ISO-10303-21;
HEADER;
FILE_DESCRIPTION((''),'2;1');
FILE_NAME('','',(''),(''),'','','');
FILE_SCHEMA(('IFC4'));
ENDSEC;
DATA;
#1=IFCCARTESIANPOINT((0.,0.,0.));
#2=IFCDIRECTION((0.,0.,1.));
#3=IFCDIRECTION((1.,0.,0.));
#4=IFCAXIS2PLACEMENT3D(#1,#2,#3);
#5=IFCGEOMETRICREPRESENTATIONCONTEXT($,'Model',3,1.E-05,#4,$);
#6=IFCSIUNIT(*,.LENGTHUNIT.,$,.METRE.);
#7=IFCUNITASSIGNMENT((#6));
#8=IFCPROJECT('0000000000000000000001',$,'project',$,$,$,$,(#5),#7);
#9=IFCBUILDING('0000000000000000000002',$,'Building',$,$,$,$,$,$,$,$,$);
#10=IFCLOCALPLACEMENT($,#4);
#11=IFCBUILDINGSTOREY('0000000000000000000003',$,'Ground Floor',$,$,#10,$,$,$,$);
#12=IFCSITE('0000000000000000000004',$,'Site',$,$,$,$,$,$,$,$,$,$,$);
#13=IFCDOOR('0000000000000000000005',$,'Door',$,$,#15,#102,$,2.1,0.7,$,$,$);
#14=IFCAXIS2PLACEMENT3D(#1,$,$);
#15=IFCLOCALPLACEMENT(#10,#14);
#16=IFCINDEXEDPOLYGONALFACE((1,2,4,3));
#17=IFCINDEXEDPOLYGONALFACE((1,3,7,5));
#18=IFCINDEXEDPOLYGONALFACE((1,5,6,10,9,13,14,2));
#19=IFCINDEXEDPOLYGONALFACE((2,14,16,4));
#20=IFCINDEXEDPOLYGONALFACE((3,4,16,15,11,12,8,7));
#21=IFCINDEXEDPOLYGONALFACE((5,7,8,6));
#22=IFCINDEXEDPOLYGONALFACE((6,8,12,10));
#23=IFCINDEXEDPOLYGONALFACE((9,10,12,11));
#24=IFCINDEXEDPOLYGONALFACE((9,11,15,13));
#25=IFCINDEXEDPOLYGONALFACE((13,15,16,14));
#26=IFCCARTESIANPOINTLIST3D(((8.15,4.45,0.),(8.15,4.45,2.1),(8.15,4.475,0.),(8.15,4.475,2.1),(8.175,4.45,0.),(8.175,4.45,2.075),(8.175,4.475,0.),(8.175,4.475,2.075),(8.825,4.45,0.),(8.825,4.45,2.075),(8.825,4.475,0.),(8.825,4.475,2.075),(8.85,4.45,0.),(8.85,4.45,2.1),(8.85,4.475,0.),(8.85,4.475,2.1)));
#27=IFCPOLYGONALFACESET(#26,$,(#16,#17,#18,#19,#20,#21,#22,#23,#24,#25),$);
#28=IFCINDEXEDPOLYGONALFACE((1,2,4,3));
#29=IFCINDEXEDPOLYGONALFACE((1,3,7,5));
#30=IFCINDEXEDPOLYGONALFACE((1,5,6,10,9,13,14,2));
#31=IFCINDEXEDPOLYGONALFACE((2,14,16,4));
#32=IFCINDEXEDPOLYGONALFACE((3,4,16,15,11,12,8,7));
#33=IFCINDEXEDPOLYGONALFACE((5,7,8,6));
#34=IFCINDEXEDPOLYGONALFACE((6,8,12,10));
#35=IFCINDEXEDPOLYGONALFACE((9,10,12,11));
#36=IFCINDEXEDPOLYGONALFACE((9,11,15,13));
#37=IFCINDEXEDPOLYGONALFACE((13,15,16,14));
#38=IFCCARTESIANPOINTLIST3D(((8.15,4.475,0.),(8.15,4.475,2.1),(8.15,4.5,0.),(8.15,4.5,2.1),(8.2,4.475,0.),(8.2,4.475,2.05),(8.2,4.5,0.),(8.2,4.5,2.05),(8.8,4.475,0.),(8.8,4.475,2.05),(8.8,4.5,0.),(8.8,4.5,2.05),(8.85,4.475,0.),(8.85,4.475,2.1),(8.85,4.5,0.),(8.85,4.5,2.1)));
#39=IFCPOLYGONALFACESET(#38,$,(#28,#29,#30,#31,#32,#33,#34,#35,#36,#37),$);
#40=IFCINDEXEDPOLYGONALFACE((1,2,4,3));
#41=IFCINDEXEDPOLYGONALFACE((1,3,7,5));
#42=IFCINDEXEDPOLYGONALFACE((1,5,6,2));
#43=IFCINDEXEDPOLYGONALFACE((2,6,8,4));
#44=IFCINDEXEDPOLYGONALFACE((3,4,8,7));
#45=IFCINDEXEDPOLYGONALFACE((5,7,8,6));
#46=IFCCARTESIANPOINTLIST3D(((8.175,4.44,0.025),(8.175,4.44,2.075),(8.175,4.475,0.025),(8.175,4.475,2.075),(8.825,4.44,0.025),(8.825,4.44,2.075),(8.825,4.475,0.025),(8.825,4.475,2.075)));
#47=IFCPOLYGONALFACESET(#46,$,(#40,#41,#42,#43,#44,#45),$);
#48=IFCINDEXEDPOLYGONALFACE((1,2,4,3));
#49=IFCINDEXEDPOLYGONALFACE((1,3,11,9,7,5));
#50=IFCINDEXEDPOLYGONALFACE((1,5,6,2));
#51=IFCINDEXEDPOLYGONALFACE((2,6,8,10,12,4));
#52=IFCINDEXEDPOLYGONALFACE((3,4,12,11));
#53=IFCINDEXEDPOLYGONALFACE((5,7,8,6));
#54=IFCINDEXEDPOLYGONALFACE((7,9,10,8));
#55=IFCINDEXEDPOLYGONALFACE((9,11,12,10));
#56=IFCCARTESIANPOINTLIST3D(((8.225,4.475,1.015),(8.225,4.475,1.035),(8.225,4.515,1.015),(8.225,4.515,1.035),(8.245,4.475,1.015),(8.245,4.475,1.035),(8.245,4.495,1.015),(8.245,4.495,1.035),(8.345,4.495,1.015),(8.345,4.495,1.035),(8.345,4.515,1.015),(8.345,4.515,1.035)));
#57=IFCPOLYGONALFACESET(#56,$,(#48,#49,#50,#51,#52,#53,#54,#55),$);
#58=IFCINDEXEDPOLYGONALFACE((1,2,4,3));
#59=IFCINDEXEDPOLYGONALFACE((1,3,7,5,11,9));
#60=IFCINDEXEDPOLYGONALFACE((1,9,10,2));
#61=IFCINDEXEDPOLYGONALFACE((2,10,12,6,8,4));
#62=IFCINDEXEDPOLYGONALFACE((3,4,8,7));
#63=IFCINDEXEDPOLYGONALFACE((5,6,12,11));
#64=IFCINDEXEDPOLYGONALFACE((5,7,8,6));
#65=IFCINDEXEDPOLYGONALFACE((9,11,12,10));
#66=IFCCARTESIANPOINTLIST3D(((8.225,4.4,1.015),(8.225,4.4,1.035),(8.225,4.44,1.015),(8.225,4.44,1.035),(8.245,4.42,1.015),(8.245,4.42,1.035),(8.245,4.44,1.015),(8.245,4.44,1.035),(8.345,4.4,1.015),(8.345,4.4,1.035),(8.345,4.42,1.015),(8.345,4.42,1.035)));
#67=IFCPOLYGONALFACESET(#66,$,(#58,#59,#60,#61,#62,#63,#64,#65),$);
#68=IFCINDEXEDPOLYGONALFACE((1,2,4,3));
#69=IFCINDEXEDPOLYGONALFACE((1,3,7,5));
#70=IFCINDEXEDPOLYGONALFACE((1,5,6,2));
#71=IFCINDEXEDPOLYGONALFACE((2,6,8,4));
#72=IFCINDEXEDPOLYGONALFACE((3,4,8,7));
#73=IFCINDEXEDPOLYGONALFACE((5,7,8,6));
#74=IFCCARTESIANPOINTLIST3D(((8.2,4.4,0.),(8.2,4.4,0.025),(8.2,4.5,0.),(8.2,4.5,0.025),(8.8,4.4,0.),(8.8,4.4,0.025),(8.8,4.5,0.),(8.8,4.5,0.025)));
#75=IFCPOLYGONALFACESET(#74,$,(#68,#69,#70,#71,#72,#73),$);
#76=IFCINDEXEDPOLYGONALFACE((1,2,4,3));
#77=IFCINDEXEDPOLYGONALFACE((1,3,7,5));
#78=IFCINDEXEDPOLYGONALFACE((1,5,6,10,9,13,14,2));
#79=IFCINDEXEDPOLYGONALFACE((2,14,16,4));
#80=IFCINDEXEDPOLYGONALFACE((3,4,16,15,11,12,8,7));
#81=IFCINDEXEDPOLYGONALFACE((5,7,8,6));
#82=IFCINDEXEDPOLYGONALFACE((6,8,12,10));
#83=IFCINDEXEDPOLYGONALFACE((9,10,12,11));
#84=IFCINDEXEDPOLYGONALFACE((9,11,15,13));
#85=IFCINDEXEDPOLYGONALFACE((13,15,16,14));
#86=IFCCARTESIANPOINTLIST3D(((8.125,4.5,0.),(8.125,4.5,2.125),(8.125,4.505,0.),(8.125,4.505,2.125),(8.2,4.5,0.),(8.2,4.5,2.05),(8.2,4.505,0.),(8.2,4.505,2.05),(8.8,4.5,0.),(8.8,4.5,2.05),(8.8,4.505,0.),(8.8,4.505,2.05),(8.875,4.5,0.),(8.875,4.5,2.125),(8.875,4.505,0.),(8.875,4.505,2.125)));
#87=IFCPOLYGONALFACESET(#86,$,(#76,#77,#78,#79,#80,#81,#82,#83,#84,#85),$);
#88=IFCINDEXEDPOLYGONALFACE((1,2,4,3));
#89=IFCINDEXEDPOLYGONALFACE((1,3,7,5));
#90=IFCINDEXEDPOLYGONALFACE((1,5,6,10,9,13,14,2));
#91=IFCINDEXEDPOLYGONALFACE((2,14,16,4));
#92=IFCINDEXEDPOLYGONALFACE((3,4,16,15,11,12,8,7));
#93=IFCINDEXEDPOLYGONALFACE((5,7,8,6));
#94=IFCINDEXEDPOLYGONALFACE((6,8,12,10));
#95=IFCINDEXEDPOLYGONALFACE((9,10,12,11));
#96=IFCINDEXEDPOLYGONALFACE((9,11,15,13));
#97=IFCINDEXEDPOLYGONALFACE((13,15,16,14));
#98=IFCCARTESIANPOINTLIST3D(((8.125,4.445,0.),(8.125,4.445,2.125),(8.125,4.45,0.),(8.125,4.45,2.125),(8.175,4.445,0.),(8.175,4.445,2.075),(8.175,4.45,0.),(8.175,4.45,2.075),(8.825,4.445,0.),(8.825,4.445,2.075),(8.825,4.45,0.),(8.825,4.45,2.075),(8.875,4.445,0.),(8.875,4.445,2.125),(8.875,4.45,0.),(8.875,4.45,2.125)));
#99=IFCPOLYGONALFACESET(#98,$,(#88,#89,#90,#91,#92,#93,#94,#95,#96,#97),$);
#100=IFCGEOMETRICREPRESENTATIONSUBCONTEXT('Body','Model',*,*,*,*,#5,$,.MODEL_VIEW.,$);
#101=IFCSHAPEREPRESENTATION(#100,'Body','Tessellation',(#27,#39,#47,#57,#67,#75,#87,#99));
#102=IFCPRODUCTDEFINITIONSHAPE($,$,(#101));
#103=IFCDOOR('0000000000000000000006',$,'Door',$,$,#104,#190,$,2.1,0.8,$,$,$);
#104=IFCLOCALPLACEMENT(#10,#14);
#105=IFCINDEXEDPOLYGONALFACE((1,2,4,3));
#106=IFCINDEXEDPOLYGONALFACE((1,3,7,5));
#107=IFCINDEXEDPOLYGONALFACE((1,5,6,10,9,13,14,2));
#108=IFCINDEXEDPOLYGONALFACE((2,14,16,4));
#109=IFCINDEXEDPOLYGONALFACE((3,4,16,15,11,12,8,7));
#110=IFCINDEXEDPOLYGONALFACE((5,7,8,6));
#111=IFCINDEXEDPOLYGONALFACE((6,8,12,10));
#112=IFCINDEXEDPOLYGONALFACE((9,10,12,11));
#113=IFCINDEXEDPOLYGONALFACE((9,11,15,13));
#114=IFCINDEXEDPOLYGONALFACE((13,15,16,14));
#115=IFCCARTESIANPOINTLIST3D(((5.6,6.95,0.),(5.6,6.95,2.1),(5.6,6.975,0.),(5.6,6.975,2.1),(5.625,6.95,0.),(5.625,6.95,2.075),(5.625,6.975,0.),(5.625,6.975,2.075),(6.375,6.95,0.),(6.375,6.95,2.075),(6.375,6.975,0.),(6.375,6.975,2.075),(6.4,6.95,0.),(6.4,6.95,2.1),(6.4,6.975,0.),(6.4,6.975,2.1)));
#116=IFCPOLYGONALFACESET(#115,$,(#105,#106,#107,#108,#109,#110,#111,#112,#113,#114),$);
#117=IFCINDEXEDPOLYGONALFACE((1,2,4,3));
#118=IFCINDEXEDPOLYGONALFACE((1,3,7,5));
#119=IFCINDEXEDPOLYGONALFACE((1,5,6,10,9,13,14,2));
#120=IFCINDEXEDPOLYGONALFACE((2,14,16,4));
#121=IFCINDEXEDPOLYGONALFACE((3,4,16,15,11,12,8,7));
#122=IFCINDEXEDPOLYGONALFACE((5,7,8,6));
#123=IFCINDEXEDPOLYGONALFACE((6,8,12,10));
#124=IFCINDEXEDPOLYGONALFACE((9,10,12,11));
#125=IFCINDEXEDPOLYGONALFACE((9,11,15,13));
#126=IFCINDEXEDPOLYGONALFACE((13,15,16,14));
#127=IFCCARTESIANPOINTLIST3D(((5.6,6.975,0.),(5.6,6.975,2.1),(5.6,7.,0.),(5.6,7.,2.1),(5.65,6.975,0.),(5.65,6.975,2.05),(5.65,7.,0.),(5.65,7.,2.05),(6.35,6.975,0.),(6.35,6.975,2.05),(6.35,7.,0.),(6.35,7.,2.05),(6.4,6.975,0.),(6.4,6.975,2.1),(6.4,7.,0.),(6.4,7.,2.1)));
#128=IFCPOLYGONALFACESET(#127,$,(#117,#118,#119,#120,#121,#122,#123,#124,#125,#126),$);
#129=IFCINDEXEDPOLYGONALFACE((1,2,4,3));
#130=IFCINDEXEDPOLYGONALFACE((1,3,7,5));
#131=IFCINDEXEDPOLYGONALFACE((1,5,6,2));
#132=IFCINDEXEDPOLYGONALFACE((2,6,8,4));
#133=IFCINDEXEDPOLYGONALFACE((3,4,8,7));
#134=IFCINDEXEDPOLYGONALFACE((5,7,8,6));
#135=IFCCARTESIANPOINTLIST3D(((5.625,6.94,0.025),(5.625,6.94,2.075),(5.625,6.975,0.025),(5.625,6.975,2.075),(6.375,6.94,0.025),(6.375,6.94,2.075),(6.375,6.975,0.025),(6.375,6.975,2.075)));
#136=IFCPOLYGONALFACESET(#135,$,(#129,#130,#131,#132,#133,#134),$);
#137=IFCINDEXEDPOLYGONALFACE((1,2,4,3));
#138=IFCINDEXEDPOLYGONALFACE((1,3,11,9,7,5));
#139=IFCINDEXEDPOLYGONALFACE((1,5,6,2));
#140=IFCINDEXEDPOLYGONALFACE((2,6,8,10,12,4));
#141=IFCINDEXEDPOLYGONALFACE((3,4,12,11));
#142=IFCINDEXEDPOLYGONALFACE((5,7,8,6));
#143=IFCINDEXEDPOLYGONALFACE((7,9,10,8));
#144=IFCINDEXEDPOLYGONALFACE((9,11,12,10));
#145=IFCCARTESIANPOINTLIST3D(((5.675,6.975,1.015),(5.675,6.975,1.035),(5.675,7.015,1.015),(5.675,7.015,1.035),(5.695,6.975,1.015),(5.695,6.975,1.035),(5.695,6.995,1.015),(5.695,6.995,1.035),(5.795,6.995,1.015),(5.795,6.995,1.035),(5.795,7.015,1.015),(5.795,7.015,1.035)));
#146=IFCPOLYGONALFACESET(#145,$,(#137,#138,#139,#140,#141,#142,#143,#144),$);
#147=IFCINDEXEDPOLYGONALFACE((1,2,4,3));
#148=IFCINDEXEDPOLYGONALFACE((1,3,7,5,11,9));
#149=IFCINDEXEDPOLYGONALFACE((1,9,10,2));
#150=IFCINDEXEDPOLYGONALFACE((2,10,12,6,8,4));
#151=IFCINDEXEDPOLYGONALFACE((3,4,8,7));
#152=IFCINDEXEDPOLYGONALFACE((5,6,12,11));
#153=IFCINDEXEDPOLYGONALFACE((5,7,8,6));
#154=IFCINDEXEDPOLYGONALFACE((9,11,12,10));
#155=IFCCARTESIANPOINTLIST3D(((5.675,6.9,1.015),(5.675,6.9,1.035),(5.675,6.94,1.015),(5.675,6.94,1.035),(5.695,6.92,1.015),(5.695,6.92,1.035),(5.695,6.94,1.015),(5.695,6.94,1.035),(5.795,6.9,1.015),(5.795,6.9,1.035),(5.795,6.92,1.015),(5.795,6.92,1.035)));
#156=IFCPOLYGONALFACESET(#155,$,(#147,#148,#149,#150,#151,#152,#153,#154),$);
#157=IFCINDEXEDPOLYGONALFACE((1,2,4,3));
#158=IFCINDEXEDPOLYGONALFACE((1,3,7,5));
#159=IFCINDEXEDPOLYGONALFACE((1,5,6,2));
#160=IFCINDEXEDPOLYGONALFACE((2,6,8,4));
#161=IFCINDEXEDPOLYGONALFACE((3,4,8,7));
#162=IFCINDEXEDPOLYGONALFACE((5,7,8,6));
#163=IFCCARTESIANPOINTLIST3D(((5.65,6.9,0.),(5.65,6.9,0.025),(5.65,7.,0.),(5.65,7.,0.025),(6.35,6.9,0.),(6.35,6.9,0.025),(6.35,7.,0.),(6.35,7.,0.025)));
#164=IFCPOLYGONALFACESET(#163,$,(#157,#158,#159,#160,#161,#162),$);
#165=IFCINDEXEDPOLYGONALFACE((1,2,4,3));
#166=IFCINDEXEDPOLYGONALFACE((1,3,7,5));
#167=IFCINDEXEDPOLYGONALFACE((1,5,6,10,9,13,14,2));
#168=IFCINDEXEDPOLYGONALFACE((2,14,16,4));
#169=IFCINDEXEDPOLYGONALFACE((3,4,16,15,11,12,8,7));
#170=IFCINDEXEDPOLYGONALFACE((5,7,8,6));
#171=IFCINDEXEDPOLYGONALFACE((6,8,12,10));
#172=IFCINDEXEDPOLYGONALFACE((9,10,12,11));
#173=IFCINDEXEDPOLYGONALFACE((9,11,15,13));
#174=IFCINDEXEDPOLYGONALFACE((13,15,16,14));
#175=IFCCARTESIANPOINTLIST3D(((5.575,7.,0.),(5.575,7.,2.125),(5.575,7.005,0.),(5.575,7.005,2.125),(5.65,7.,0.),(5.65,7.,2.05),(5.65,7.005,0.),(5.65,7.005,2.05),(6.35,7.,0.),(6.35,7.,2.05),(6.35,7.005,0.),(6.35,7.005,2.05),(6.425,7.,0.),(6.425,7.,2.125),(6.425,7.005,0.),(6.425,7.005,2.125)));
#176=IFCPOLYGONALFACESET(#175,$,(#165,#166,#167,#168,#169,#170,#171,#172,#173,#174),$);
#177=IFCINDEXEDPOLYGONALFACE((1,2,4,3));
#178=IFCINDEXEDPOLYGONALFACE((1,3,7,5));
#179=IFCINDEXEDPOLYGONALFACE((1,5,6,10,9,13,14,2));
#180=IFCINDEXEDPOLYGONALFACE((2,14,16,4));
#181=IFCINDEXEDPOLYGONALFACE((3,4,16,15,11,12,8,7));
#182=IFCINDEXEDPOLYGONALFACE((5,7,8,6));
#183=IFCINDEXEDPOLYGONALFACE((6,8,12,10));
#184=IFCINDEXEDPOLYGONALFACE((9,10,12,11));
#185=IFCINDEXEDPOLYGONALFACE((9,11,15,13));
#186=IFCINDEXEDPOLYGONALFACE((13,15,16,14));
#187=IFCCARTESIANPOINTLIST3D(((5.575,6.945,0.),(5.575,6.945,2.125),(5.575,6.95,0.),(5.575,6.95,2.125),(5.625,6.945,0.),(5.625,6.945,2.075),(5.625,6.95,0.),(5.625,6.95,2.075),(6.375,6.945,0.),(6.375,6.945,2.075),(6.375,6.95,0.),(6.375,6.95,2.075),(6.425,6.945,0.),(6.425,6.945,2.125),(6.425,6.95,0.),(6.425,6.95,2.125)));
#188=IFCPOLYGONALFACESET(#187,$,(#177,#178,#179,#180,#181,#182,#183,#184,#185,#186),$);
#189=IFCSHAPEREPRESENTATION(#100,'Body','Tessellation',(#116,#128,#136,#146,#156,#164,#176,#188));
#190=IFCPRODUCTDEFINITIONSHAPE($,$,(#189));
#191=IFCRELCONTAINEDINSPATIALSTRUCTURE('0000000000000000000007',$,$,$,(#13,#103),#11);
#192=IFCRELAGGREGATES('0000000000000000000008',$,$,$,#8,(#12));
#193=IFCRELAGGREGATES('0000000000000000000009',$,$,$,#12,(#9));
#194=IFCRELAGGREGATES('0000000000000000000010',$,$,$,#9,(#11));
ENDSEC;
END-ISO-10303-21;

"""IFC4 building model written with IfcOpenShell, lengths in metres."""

from ifc_helpers import new_model, si_unit, frame, origin_with_axes, place, context, subcontext, project, spatial, line, indexed_curve, outline, extrude, element, save


model = new_model("IFC4")

# Units and contexts
model_context = context("Model", 3, precision=1e-05, world=origin_with_axes())
body_context = subcontext(model_context, "Body", "Model", "MODEL_VIEW")
ifc_project = project(units=[si_unit("LENGTHUNIT", "METRE")], contexts=[model_context])

# Site, building, storey
site = spatial("IfcSite", under=ifc_project, Name="Site")
building = spatial("IfcBuilding", under=site, Name="Building")
storey_placement = place(None, origin_with_axes())
storey = spatial("IfcBuildingStorey", under=building, at=storey_placement, Name="Ground Floor")

# Doors
door_1_placement = place(storey_placement, frame((8.85, 4.5, 0.0), z_axis=(0.0, 0.0, 1.0), x_axis=(-1.0, 0.0, 0.0)))
element("IfcDoor", 1, at=door_1_placement, inside=storey, Name="Door", OverallHeight=2.1, OverallWidth=0.7, context=body_context, shape_type="SweptSolid", body=[
    extrude(outline(indexed_curve([(0.0, 0.0), (0.0, 2.1), (0.7, 2.1), (0.7, 0.0), (0.675, 0.0), (0.675, 2.075), (0.025, 2.075), (0.025, 0.0)], segments=[line(1, 2, 3, 4, 5, 6, 7, 8, 1)])), frame((0.0, 0.025, 0.0), z_axis=(0.0, -1.0, 0.0), x_axis=(1.0, 0.0, 0.0)), (0.0, 0.0, -1.0), 0.025),
    extrude(outline(indexed_curve([(0.0, 0.0), (0.0, 2.1), (0.7, 2.1), (0.7, 0.0), (0.65, 0.0), (0.65, 2.05), (0.05, 2.05), (0.05, 0.0)], segments=[line(1, 2, 3, 4, 5, 6, 7, 8, 1)])), frame((0.0, 0.0, 0.0), z_axis=(0.0, -1.0, 0.0), x_axis=(1.0, 0.0, 0.0)), (0.0, 0.0, -1.0), 0.025),
    extrude(outline(indexed_curve([(0.0, 0.0), (0.65, 0.0), (0.65, 0.035), (0.0, 0.035)], segments=[line(1, 2, 3, 4, 1)])), frame((0.025, 0.025, 0.025), z_axis=(0.0, 0.0, 1.0), x_axis=(1.0, 0.0, 0.0)), (0.0, 0.0, 1.0), 2.05),
    extrude(outline(indexed_curve([(0.0, 0.0), (0.0, -0.04), (-0.12, -0.04), (-0.12, -0.02), (-0.02, -0.02), (-0.02, 0.0)], segments=[line(1, 2, 3, 4, 5, 6, 1)])), frame((0.625, 0.025, 1.015), z_axis=(0.0, 0.0, 1.0), x_axis=(1.0, 0.0, 0.0)), (0.0, 0.0, 1.0), 0.02),
    extrude(outline(indexed_curve([(0.0, 0.0), (0.0, 0.04), (-0.12, 0.04), (-0.12, 0.02), (-0.02, 0.02), (-0.02, 0.0)], segments=[line(1, 2, 3, 4, 5, 6, 1)])), frame((0.625, 0.06, 1.015), z_axis=(0.0, 0.0, 1.0), x_axis=(1.0, 0.0, 0.0)), (0.0, 0.0, 1.0), 0.02),
    extrude(outline(indexed_curve([(0.0, 0.0), (0.6, 0.0), (0.6, 0.1), (0.0, 0.1)], segments=[line(1, 2, 3, 4, 1)])), frame((0.05, 0.0, 0.0), z_axis=(0.0, 0.0, 1.0), x_axis=(1.0, 0.0, 0.0)), (0.0, 0.0, 1.0), 0.025),
    extrude(outline(indexed_curve([(0.0, 0.0), (0.0, 2.125), (0.75, 2.125), (0.75, 0.0), (0.675, 0.0), (0.675, 2.05), (0.075, 2.05), (0.075, 0.0)], segments=[line(1, 2, 3, 4, 5, 6, 7, 8, 1)])), frame((-0.025, -0.005, 0.0), z_axis=(0.0, -1.0, 0.0), x_axis=(1.0, 0.0, 0.0)), (0.0, 0.0, -1.0), 0.005),
    extrude(outline(indexed_curve([(0.0, 0.0), (0.0, 2.125), (0.75, 2.125), (0.75, 0.0), (0.7, 0.0), (0.7, 2.075), (0.05, 2.075), (0.05, 0.0)], segments=[line(1, 2, 3, 4, 5, 6, 7, 8, 1)])), frame((-0.025, 0.05, 0.0), z_axis=(0.0, -1.0, 0.0), x_axis=(1.0, 0.0, 0.0)), (0.0, 0.0, -1.0), 0.005),
])
door_2_placement = place(storey_placement, frame((6.4, 7.0, 0.0), z_axis=(0.0, 0.0, 1.0), x_axis=(-1.0, 0.0, 0.0)))
element("IfcDoor", 2, at=door_2_placement, inside=storey, Name="Door", OverallHeight=2.1, OverallWidth=0.8, context=body_context, shape_type="SweptSolid", body=[
    extrude(outline(indexed_curve([(0.0, 0.0), (0.0, 2.1), (0.8, 2.1), (0.8, 0.0), (0.775, 0.0), (0.775, 2.075), (0.025, 2.075), (0.025, 0.0)], segments=[line(1, 2, 3, 4, 5, 6, 7, 8, 1)])), frame((0.0, 0.025, 0.0), z_axis=(0.0, -1.0, 0.0), x_axis=(1.0, 0.0, 0.0)), (0.0, 0.0, -1.0), 0.025),
    extrude(outline(indexed_curve([(0.0, 0.0), (0.0, 2.1), (0.8, 2.1), (0.8, 0.0), (0.75, 0.0), (0.75, 2.05), (0.05, 2.05), (0.05, 0.0)], segments=[line(1, 2, 3, 4, 5, 6, 7, 8, 1)])), frame((0.0, 0.0, 0.0), z_axis=(0.0, -1.0, 0.0), x_axis=(1.0, 0.0, 0.0)), (0.0, 0.0, -1.0), 0.025),
    extrude(outline(indexed_curve([(0.0, 0.0), (0.75, 0.0), (0.75, 0.035), (0.0, 0.035)], segments=[line(1, 2, 3, 4, 1)])), frame((0.025, 0.025, 0.025), z_axis=(0.0, 0.0, 1.0), x_axis=(1.0, 0.0, 0.0)), (0.0, 0.0, 1.0), 2.05),
    extrude(outline(indexed_curve([(0.0, 0.0), (0.0, -0.04), (-0.12, -0.04), (-0.12, -0.02), (-0.02, -0.02), (-0.02, 0.0)], segments=[line(1, 2, 3, 4, 5, 6, 1)])), frame((0.725, 0.025, 1.015), z_axis=(0.0, 0.0, 1.0), x_axis=(1.0, 0.0, 0.0)), (0.0, 0.0, 1.0), 0.02),
    extrude(outline(indexed_curve([(0.0, 0.0), (0.0, 0.04), (-0.12, 0.04), (-0.12, 0.02), (-0.02, 0.02), (-0.02, 0.0)], segments=[line(1, 2, 3, 4, 5, 6, 1)])), frame((0.725, 0.06, 1.015), z_axis=(0.0, 0.0, 1.0), x_axis=(1.0, 0.0, 0.0)), (0.0, 0.0, 1.0), 0.02),
    extrude(outline(indexed_curve([(0.0, 0.0), (0.7, 0.0), (0.7, 0.1), (0.0, 0.1)], segments=[line(1, 2, 3, 4, 1)])), frame((0.05, 0.0, 0.0), z_axis=(0.0, 0.0, 1.0), x_axis=(1.0, 0.0, 0.0)), (0.0, 0.0, 1.0), 0.025),
    extrude(outline(indexed_curve([(0.0, 0.0), (0.0, 2.125), (0.85, 2.125), (0.85, 0.0), (0.775, 0.0), (0.775, 2.05), (0.075, 2.05), (0.075, 0.0)], segments=[line(1, 2, 3, 4, 5, 6, 7, 8, 1)])), frame((-0.025, -0.005, 0.0), z_axis=(0.0, -1.0, 0.0), x_axis=(1.0, 0.0, 0.0)), (0.0, 0.0, -1.0), 0.005),
    extrude(outline(indexed_curve([(0.0, 0.0), (0.0, 2.125), (0.85, 2.125), (0.85, 0.0), (0.8, 0.0), (0.8, 2.075), (0.05, 2.075), (0.05, 0.0)], segments=[line(1, 2, 3, 4, 5, 6, 7, 8, 1)])), frame((-0.025, 0.05, 0.0), z_axis=(0.0, -1.0, 0.0), x_axis=(1.0, 0.0, 0.0)), (0.0, 0.0, -1.0), 0.005),
])

save(model, "model.ifc")
